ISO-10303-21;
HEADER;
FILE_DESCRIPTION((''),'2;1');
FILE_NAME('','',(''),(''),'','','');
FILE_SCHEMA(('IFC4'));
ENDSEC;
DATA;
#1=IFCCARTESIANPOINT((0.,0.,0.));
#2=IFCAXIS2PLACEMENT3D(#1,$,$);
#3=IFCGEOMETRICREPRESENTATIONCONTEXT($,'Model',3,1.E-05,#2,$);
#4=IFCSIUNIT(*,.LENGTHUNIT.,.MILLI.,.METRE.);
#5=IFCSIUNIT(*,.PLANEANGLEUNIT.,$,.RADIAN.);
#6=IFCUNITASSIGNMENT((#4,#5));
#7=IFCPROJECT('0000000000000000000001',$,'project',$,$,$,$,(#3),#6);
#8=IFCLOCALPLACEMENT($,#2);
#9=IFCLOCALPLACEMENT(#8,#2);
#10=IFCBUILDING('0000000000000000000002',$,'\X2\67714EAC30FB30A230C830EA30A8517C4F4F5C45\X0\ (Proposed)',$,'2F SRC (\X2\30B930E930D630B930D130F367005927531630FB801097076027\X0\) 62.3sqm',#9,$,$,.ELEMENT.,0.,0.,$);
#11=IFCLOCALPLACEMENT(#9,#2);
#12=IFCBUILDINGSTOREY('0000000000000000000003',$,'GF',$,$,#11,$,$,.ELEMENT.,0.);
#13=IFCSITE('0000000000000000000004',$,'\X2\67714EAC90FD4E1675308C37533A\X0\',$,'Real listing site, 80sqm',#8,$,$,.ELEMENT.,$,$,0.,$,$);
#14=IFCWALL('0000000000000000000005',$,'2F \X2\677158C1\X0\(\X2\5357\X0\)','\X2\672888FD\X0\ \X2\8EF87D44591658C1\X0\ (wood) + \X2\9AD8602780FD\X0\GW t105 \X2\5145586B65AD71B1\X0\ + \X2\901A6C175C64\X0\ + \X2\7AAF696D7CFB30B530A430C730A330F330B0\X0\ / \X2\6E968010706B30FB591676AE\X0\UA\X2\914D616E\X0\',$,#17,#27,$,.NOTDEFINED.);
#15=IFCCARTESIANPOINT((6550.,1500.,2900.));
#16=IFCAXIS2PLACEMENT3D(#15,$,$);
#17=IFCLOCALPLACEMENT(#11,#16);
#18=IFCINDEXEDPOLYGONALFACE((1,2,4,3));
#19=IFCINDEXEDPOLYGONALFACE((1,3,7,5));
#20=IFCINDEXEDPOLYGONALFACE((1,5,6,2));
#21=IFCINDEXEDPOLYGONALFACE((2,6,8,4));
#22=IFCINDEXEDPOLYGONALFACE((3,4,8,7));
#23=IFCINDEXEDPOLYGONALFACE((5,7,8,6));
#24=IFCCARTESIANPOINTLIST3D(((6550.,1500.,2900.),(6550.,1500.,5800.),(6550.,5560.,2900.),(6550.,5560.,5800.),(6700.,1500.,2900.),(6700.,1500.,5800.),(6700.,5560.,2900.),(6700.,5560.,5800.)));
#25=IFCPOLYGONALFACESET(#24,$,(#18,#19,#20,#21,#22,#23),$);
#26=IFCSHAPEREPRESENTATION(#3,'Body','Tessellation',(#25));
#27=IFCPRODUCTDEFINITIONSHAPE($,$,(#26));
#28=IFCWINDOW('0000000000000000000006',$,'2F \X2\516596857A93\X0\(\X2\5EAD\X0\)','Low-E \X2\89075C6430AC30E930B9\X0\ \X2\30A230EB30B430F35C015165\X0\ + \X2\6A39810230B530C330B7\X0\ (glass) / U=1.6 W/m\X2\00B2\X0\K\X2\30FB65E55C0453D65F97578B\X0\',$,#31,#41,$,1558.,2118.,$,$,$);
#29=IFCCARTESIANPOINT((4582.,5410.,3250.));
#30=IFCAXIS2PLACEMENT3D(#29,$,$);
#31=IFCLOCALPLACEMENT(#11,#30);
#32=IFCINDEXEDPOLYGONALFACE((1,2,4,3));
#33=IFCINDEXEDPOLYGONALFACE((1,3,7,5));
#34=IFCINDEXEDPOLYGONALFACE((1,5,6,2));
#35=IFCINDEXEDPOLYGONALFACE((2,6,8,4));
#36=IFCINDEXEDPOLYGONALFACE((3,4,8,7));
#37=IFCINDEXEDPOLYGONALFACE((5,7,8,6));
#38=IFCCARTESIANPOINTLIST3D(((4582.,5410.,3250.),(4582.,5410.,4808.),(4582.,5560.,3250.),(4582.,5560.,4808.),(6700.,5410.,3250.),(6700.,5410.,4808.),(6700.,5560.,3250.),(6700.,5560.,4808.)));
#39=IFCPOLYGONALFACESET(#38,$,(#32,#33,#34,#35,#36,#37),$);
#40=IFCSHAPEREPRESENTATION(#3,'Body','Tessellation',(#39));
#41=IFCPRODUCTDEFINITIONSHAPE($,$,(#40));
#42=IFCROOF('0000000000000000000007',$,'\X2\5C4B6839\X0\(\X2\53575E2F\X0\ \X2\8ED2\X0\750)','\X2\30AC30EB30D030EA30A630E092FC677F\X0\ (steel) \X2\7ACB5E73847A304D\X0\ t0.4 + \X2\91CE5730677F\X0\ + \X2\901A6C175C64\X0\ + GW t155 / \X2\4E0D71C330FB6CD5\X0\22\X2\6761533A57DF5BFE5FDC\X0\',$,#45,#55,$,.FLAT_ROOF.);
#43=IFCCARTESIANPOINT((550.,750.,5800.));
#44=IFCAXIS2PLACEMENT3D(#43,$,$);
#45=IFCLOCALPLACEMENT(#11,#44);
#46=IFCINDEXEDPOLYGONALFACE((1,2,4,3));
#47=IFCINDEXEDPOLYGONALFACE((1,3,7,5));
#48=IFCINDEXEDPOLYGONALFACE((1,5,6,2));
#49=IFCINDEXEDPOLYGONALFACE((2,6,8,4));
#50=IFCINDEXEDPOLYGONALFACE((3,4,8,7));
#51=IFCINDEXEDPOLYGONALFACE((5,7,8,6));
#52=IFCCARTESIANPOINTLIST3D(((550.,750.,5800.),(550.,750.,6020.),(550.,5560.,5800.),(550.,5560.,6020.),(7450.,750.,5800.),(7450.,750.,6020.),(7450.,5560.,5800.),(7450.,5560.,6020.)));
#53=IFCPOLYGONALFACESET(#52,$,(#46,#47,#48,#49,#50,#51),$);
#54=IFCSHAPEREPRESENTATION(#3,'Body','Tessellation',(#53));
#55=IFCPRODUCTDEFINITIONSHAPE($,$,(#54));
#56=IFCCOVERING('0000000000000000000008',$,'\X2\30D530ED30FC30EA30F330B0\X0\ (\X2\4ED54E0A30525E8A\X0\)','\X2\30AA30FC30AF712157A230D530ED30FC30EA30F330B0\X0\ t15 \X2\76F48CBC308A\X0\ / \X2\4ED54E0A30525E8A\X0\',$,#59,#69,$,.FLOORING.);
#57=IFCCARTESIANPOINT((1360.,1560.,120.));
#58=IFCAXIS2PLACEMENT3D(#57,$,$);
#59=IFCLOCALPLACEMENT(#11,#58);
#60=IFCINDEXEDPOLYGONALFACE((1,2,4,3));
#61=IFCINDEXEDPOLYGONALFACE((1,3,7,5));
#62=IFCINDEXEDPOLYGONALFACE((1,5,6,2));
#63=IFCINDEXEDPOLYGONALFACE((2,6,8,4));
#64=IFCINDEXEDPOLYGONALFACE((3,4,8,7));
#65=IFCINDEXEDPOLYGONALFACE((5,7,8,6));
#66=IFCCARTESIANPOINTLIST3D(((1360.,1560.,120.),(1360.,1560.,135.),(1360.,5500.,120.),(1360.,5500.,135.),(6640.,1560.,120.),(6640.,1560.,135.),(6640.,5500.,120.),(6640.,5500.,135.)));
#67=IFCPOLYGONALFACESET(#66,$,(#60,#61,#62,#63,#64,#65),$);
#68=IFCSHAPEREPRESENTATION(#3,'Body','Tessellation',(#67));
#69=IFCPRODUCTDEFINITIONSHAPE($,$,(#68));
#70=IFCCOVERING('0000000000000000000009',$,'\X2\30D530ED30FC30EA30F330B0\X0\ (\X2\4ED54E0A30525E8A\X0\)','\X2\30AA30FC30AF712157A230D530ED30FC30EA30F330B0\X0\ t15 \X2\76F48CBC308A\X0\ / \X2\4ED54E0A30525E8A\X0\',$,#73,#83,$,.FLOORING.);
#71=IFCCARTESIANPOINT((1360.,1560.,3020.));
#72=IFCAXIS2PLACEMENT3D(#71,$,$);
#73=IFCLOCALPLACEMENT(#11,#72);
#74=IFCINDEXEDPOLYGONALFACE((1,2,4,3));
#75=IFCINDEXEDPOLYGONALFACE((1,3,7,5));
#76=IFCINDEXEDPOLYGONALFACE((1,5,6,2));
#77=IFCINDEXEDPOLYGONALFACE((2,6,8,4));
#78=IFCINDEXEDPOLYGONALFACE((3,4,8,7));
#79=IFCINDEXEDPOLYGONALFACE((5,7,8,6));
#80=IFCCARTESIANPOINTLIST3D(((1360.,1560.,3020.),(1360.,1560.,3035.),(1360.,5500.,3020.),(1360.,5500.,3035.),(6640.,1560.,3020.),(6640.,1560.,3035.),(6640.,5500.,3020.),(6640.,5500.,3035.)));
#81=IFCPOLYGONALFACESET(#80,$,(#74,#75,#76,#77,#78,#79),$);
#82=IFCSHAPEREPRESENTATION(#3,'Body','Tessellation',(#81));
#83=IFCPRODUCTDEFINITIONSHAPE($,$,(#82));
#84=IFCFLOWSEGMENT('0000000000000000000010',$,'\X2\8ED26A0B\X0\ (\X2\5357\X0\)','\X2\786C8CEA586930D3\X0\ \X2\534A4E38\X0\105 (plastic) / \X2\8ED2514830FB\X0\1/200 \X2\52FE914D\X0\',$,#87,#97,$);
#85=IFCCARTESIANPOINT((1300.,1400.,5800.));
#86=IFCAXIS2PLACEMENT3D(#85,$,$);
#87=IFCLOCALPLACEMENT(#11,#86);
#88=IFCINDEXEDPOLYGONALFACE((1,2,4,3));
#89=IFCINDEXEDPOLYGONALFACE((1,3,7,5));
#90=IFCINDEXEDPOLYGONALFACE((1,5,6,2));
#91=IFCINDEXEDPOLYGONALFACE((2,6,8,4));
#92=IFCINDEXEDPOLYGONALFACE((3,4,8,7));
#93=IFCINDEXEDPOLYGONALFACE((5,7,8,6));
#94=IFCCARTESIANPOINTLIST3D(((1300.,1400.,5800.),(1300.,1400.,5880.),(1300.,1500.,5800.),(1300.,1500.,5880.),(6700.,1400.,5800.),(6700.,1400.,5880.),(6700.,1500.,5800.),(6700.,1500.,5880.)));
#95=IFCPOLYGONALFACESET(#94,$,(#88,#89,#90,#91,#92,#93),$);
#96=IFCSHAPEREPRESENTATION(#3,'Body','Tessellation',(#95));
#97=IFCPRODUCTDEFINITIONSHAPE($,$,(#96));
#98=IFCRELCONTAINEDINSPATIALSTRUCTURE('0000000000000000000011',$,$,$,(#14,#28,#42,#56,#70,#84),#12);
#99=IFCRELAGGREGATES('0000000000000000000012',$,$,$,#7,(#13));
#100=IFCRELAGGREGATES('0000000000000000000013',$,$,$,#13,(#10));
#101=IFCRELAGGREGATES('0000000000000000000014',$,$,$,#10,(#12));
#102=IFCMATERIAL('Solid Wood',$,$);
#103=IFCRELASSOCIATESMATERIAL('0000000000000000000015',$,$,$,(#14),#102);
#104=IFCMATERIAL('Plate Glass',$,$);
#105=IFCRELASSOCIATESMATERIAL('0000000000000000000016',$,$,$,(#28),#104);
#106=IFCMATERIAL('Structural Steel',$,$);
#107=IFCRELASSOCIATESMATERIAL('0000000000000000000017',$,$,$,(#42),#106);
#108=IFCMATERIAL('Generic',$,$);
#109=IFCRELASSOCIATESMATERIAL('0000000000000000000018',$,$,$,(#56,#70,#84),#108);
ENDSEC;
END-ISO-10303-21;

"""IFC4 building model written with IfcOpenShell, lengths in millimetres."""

from ifc_helpers import new_model, si_unit, frame, frame_2d, origin, place, context, project, spatial, rectangle, extrude, material, element, fill, save


model = new_model("IFC4")

# Units and contexts
model_context = context("Model", 3, precision=1e-05, world=origin())
ifc_project = project(units=[si_unit("LENGTHUNIT", "METRE", prefix="MILLI"), si_unit("PLANEANGLEUNIT", "RADIAN")], contexts=[model_context])

# Site, building, storey
site_placement = place(None, origin())
site = spatial("IfcSite", under=ifc_project, at=site_placement, Name="東京都世田谷区", ObjectType="Real listing site, 80sqm", CompositionType="ELEMENT", RefElevation=0.0)
building_placement = place(site_placement, origin())
building = spatial("IfcBuilding", under=site, at=building_placement, Name="東京・アトリエ兼住居 (Proposed)", ObjectType="2F SRC (スラブスパン最大化・耐震性) 62.3sqm", CompositionType="ELEMENT", ElevationOfRefHeight=0.0, ElevationOfTerrain=0.0)
storey_placement = place(building_placement, origin())
storey = spatial("IfcBuildingStorey", under=building, at=storey_placement, Name="GF", CompositionType="ELEMENT", Elevation=0.0)

# Shared definitions
ifc_material_1 = material(Name="Solid Wood")

# Wall, opening, window
ifc_material_2 = material(Name="Plate Glass")
wall_1_placement = place(storey_placement, frame((6550.0, 1500.0, 2900.0)))
wall_1 = element("IfcWall", 1, at=wall_1_placement, inside=storey, material=ifc_material_1, Name="2F 東壁(南)", Description="木製 軸組外壁 (wood) + 高性能GW t105 充填断熱 + 通気層 + 窯業系サイディング / 準耐火・外皮UA配慮", PredefinedType="NOTDEFINED", context=model_context, shape_type="SweptSolid", body=[
    extrude(rectangle(XDim=150.0, YDim=4060.0, at=frame_2d((75.0, 2030.0))), frame((6550.0, 1500.0, 2900.0)), (0.0, 0.0, 1.0), 2900.0),
])
opening_1_placement = place(storey_placement, frame((4582.0, 5410.0, 3250.0)))
opening_1 = element("IfcOpeningElement", 2, at=opening_1_placement, cuts=wall_1, PredefinedType="NOTDEFINED", context=model_context, shape_type="SweptSolid", body=[
    extrude(rectangle(XDim=2118.0, YDim=150.0, at=frame_2d((1059.0, 75.0))), frame((4582.0, 5410.0, 3250.0)), (0.0, 0.0, 1.0), 1558.0),
])
window_1_placement = place(storey_placement, frame((4582.0, 5410.0, 3250.0)))
window_1 = element("IfcWindow", 3, at=window_1_placement, inside=storey, material=ifc_material_2, Name="2F 入隅窓(庭)", Description="Low-E 複層ガラス アルゴン封入 + 樹脂サッシ (glass) / U=1.6 W/m²K・日射取得型", OverallHeight=1558.0, OverallWidth=2118.0, context=model_context, shape_type="SweptSolid", body=[
    extrude(rectangle(XDim=2118.0, YDim=150.0, at=frame_2d((1059.0, 75.0))), frame((4582.0, 5410.0, 3250.0)), (0.0, 0.0, 1.0), 1558.0),
])
fill(opening_1, window_1)

# Roof
ifc_material_3 = material(Name="Structural Steel")
for number, where, name in (
    (4, (550.0, 750.0, 5800.0), "屋根(南帯 軒750)"),
):
    element("IfcRoof", number, at=place(storey_placement, frame(where)), inside=storey, material=ifc_material_3, Name=name, Description="ガルバリウム鋼板 (steel) 立平葺き t0.4 + 野地板 + 通気層 + GW t155 / 不燃・法22条区域対応", PredefinedType="FLAT_ROOF", context=model_context, shape_type="SweptSolid", body=[
        extrude(rectangle(XDim=6900.0, YDim=4810.0, at=frame_2d((3450.0, 2405.0))), frame((550.0, 750.0, 5800.0)), (0.0, 0.0, 1.0), 220.0),
    ])

# Coverings
ifc_material_4 = material(Name="Generic")
covering_1_placement = place(storey_placement, frame((1360.0, 1560.0, 120.0)))
element("IfcCovering", 5, at=covering_1_placement, inside=storey, material=ifc_material_4, Name="フローリング (仕上げ床)", Description="オーク無垢フローリング t15 直貼り / 仕上げ床", PredefinedType="FLOORING", context=model_context, shape_type="SweptSolid", body=[
    extrude(rectangle(XDim=5280.0, YDim=3940.0, at=frame_2d((2640.0, 1970.0))), frame((1360.0, 1560.0, 120.0)), (0.0, 0.0, 1.0), 15.0),
])
covering_2_placement = place(storey_placement, frame((1360.0, 1560.0, 3020.0)))
element("IfcCovering", 6, at=covering_2_placement, inside=storey, material=ifc_material_4, Name="フローリング (仕上げ床)", Description="オーク無垢フローリング t15 直貼り / 仕上げ床", PredefinedType="FLOORING", context=model_context, shape_type="SweptSolid", body=[
    extrude(rectangle(XDim=5280.0, YDim=3940.0, at=frame_2d((2640.0, 1970.0))), frame((1360.0, 1560.0, 3020.0)), (0.0, 0.0, 1.0), 15.0),
])

# Flow segment
flow_segment_placement = place(storey_placement, frame((1300.0, 1400.0, 5800.0)))
element("IfcFlowSegment", 7, at=flow_segment_placement, inside=storey, material=ifc_material_4, Name="軒樋 (南)", Description="硬質塩ビ 半丸105 (plastic) / 軒先・1/200 勾配", context=model_context, shape_type="SweptSolid", body=[
    extrude(rectangle(XDim=5400.0, YDim=100.0, at=frame_2d((2700.0, 50.0))), frame((1300.0, 1400.0, 5800.0)), (0.0, 0.0, 1.0), 80.0),
])

save(model, "model.ifc")
